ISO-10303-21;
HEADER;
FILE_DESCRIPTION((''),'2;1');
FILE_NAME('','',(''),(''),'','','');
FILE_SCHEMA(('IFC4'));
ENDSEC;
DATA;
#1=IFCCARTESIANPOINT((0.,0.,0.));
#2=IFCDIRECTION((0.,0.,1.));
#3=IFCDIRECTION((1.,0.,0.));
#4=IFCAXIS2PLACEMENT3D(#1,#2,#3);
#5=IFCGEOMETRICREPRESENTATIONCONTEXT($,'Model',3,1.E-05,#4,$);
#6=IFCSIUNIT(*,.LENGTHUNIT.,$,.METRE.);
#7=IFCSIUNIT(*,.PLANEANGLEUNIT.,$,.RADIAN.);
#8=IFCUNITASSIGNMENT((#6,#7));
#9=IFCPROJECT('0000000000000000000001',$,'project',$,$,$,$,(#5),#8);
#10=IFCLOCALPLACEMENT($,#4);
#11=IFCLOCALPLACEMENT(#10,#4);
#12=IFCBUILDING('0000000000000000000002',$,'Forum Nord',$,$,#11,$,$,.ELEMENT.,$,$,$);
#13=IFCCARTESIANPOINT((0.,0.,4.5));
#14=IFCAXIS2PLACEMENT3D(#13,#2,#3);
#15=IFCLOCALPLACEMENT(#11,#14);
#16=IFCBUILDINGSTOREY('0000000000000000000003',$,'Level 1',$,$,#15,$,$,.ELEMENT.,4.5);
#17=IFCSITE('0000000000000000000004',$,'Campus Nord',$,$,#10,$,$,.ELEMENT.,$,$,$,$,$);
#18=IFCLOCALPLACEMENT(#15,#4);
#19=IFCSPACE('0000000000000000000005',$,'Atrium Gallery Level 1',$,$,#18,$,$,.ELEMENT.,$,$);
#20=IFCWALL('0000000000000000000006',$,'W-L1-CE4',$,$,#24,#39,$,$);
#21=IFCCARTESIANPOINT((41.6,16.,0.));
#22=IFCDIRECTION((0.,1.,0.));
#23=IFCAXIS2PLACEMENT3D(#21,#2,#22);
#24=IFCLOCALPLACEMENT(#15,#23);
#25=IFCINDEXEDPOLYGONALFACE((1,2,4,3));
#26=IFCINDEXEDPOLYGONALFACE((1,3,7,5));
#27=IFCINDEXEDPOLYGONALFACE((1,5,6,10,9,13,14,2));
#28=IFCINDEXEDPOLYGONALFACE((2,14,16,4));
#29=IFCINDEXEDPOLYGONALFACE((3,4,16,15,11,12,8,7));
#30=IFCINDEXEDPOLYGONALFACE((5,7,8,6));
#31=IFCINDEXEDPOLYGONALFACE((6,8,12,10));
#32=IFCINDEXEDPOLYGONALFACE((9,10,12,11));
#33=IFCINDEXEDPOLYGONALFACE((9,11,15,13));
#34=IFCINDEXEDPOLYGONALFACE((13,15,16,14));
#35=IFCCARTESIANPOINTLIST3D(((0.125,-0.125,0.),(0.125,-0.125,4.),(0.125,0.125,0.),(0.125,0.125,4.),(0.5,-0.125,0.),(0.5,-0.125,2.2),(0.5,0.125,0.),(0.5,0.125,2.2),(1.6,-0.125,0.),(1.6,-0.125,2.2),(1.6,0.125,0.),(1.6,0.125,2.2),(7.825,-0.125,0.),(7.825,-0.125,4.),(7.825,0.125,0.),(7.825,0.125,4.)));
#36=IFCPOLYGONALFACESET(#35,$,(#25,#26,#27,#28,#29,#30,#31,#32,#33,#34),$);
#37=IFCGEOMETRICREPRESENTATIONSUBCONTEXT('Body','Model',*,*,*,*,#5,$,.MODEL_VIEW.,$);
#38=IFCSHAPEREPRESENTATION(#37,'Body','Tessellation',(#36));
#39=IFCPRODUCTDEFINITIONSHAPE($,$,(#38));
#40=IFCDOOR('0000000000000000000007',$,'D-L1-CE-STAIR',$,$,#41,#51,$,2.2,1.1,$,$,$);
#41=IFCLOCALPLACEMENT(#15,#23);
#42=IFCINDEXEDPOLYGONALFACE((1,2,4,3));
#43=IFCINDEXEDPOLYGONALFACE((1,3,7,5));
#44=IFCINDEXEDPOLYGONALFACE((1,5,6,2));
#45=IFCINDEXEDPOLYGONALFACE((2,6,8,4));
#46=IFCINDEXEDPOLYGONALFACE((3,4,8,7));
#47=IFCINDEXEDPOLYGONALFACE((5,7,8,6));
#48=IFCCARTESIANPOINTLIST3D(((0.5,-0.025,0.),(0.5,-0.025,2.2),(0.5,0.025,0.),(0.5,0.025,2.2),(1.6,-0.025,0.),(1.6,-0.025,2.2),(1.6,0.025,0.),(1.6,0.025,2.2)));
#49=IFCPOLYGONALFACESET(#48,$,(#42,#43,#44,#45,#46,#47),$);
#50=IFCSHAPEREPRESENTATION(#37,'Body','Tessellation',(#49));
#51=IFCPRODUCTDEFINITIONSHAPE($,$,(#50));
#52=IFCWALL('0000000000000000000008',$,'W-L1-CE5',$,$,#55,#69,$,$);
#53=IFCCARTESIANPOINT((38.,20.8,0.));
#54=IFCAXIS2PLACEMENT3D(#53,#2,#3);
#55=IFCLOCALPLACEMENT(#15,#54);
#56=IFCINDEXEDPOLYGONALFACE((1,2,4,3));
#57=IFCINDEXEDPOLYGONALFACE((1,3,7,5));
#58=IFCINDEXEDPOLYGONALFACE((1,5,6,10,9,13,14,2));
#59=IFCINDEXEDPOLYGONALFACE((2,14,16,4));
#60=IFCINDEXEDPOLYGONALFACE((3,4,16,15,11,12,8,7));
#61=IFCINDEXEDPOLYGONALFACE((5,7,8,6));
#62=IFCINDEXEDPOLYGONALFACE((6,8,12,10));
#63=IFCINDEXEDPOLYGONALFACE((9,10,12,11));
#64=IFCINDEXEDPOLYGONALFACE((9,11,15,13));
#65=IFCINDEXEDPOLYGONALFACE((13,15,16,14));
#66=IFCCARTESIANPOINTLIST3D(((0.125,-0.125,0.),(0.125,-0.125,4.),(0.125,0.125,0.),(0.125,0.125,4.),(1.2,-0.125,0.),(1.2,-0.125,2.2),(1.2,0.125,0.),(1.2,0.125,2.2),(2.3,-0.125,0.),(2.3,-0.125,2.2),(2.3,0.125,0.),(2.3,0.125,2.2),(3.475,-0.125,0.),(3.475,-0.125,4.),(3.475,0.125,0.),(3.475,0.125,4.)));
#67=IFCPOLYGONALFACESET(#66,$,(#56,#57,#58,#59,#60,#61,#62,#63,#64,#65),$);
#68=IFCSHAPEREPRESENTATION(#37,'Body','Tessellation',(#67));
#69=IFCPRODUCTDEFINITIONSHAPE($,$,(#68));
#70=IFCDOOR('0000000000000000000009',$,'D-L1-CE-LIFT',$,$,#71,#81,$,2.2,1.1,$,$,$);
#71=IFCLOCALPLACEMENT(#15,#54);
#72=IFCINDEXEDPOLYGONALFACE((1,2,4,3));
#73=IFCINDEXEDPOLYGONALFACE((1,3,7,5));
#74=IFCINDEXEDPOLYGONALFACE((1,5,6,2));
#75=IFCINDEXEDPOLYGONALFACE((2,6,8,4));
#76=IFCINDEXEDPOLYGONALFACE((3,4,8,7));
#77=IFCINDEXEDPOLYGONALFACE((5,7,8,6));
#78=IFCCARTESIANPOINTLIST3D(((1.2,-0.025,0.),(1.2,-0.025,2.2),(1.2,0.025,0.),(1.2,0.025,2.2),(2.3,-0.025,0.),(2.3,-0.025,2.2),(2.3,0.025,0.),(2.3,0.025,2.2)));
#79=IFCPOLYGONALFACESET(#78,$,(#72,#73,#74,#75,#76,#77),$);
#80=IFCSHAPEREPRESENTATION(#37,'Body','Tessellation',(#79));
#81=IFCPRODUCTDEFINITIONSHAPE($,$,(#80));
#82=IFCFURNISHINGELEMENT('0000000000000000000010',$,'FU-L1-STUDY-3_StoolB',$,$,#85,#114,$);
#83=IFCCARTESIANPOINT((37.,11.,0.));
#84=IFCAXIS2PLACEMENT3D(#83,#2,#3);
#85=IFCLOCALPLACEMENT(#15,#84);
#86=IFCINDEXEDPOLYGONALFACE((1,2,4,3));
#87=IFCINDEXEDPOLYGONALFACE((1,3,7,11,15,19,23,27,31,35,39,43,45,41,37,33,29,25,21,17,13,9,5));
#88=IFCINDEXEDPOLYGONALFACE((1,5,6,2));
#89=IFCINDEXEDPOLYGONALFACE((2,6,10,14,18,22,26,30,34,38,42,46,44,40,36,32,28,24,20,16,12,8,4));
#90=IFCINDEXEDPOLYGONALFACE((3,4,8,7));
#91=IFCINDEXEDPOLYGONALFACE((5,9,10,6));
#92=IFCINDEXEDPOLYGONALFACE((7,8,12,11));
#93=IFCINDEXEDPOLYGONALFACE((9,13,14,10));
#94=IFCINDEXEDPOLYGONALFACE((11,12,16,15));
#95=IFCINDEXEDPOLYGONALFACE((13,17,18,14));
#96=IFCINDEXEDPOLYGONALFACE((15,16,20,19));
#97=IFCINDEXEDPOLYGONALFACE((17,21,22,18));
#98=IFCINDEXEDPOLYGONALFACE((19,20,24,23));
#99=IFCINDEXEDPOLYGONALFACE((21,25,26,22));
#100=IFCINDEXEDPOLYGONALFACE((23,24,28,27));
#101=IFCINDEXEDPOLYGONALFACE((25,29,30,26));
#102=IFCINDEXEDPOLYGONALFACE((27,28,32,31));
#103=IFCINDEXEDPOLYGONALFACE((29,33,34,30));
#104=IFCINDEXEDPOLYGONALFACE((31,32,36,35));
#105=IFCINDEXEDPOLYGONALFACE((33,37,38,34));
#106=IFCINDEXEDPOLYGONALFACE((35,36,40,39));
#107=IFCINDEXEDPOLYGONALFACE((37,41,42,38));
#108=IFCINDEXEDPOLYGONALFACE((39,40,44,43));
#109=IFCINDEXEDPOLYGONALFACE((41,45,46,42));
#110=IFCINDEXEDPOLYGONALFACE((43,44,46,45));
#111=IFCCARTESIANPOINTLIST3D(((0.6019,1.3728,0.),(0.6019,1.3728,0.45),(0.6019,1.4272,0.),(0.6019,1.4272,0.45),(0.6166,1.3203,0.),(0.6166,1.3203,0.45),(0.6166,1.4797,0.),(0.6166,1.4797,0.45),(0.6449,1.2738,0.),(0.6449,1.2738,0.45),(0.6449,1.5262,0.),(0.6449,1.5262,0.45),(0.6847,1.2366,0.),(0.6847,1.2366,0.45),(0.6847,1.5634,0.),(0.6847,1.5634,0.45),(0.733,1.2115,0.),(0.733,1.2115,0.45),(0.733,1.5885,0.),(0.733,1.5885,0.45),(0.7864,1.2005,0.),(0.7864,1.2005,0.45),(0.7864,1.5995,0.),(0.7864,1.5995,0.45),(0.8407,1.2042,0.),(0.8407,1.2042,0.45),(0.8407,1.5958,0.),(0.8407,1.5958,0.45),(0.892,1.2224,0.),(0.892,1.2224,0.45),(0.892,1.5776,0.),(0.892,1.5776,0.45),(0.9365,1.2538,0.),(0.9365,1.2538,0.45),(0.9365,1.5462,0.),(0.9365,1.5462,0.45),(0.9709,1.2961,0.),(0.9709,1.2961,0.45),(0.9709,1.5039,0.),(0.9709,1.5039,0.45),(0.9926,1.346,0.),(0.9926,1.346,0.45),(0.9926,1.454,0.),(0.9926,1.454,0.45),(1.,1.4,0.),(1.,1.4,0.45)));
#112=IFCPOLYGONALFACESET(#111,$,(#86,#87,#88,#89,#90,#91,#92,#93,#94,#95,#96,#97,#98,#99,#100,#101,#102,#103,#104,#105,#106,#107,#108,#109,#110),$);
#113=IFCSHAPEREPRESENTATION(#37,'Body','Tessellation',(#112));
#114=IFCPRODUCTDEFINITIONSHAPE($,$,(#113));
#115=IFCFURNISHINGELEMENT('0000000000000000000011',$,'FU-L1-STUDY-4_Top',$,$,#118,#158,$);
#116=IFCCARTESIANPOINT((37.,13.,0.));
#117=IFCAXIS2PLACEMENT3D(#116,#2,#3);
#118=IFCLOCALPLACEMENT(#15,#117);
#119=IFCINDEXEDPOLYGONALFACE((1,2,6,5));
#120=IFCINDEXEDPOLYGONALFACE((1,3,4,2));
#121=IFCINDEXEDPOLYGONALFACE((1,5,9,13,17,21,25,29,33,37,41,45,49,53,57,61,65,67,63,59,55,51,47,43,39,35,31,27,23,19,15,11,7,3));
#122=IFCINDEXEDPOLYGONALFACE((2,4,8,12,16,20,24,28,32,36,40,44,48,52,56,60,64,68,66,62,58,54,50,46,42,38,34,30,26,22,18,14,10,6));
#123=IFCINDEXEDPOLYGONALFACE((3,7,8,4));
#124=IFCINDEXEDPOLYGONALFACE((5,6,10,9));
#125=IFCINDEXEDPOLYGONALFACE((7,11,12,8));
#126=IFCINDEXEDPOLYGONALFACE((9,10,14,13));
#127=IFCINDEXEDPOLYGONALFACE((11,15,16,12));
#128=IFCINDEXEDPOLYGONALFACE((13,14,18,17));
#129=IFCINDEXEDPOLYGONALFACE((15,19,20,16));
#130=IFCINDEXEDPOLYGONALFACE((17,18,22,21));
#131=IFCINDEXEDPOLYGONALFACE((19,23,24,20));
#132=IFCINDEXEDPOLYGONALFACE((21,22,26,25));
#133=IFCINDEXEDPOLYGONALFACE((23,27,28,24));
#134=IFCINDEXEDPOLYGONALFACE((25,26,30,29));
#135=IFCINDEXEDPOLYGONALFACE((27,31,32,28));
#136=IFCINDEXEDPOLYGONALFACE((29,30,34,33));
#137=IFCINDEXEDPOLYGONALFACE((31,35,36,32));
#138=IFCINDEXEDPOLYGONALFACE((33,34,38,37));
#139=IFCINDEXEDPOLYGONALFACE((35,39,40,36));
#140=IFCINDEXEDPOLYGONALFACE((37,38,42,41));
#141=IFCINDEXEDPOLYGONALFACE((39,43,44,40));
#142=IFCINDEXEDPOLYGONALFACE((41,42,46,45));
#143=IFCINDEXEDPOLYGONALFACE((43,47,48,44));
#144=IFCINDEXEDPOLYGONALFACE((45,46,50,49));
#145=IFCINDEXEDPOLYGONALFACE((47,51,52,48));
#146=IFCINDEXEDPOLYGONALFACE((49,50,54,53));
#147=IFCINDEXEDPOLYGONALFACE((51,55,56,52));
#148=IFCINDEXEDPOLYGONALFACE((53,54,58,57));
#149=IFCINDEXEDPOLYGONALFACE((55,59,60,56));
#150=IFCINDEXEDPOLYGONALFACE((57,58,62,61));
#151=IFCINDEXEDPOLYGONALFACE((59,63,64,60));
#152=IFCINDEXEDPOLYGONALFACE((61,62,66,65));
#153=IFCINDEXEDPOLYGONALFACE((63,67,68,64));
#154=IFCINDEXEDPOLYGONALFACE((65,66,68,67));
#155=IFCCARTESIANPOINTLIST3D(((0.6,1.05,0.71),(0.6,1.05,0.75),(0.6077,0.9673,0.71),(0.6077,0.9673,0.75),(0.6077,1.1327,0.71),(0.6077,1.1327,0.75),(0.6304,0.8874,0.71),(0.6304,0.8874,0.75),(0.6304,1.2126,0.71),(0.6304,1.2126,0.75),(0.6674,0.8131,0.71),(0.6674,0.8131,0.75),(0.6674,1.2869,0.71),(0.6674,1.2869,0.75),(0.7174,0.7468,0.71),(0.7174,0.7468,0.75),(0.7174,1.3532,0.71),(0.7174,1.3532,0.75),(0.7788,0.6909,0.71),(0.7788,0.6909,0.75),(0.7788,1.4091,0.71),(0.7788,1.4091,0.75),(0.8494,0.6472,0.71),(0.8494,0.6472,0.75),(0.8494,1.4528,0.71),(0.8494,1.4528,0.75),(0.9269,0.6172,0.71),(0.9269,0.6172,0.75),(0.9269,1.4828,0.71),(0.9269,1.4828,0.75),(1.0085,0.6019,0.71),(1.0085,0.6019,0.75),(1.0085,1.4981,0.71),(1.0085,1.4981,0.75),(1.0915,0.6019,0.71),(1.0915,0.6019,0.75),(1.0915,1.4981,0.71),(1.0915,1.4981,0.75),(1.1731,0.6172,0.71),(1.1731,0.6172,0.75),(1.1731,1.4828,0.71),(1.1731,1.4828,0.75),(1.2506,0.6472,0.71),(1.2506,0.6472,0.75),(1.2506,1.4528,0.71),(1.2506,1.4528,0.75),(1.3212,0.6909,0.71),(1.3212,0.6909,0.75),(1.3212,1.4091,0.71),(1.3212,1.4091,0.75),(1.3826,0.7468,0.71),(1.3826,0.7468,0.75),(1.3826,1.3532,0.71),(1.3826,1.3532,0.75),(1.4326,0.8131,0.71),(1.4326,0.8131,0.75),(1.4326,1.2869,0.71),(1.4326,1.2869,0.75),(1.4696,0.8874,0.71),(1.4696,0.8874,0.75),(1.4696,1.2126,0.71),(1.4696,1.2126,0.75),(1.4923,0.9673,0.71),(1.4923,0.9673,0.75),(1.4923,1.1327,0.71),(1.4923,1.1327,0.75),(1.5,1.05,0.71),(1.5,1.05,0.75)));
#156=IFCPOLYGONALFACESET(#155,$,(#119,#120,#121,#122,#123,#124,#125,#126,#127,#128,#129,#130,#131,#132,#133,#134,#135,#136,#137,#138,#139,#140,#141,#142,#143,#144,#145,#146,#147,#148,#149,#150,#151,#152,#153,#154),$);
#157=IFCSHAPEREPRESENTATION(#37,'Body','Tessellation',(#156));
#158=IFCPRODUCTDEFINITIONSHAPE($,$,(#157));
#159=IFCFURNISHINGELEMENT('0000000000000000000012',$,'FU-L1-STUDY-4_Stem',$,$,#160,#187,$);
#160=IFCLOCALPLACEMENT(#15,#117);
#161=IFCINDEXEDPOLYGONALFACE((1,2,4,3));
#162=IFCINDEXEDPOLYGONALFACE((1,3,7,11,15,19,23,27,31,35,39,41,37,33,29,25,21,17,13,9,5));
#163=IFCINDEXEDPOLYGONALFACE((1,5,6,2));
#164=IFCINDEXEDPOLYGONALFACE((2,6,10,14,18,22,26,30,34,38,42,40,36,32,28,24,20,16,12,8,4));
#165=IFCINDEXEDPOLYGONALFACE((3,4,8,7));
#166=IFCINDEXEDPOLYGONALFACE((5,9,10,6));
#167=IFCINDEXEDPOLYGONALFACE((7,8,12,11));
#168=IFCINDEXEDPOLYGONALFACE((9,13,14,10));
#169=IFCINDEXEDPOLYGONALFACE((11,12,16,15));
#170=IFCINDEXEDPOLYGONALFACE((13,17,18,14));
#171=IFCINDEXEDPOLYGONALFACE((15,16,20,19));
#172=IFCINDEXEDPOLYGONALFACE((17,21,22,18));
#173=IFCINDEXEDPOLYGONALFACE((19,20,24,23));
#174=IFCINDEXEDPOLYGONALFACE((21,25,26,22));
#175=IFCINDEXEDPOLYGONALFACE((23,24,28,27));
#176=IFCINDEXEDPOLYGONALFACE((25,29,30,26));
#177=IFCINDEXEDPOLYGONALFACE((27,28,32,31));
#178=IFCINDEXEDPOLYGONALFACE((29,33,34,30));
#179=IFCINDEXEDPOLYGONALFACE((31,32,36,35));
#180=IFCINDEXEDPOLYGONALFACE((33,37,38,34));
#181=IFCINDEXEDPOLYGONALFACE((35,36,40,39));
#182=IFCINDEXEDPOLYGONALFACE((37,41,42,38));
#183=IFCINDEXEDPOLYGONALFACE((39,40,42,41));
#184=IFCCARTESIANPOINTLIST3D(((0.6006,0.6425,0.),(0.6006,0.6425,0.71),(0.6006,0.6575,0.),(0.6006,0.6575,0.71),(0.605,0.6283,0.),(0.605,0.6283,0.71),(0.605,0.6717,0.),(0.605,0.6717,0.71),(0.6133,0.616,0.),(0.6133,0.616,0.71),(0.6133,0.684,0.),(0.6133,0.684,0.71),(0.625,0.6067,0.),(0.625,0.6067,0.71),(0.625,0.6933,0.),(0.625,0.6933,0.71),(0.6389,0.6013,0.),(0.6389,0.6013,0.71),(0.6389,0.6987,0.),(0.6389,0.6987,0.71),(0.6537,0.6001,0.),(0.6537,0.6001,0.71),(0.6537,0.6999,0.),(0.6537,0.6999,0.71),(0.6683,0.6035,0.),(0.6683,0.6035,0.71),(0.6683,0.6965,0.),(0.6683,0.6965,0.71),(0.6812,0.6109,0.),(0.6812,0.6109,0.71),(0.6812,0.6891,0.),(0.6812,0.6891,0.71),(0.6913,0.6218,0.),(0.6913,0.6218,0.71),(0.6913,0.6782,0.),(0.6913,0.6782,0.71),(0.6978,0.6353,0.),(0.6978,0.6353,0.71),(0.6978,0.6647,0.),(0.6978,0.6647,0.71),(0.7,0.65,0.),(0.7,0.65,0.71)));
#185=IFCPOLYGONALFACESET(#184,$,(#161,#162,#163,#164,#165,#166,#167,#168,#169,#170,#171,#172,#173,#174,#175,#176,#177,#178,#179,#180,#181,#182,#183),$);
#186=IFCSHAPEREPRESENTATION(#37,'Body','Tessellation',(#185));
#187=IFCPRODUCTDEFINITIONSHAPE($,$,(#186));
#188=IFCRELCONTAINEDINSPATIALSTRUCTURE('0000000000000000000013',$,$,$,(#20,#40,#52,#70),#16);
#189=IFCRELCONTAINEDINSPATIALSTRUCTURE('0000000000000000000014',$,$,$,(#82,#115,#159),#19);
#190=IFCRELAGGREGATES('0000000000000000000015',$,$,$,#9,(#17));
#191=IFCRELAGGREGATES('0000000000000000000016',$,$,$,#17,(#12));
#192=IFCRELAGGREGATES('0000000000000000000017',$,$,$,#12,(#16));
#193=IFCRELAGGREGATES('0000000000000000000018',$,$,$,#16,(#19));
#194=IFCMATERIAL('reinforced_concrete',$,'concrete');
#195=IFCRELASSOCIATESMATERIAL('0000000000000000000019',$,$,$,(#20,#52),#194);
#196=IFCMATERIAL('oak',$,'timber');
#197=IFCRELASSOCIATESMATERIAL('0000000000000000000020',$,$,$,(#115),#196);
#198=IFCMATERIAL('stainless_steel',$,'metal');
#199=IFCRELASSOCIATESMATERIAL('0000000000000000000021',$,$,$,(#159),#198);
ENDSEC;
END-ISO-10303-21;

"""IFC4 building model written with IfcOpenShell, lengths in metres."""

from ifc_helpers import new_model, si_unit, frame, frame_2d, origin_with_axes, place, context, subcontext, project, spatial, polyline, rectangle, circle, outline, extrude, material, element, fill, save


model = new_model("IFC4")

# Units and contexts
model_context = context("Model", 3, precision=1e-05, world=origin_with_axes())
body_context = subcontext(model_context, "Body", "Model", "MODEL_VIEW")
ifc_project = project(units=[si_unit("LENGTHUNIT", "METRE"), si_unit("PLANEANGLEUNIT", "RADIAN")], contexts=[model_context])

# Site, building, storey
site_placement = place(None, origin_with_axes())
site = spatial("IfcSite", under=ifc_project, at=site_placement, Name="Campus Nord", CompositionType="ELEMENT")
building_placement = place(site_placement, origin_with_axes())
building = spatial("IfcBuilding", under=site, at=building_placement, Name="Forum Nord", CompositionType="ELEMENT")
storey_placement = place(building_placement, frame((0.0, 0.0, 4.5), z_axis=(0.0, 0.0, 1.0), x_axis=(1.0, 0.0, 0.0)))
storey = spatial("IfcBuildingStorey", under=building, at=storey_placement, Name="Level 1", CompositionType="ELEMENT", Elevation=4.5)

# Shared definitions
ifc_material_1 = material(Name="reinforced_concrete", Category="concrete")

# Walls, openings, doors
wall_1_placement = place(storey_placement, frame((41.6, 16.0, 0.0), z_axis=(0.0, 0.0, 1.0), x_axis=(0.0, 1.0, 0.0)))
wall_1 = element("IfcWall", 1, at=wall_1_placement, inside=storey, material=ifc_material_1, Name="W-L1-CE4", context=body_context, shape_type="SweptSolid", body=[
    extrude(outline(polyline([(0.125, -0.125), (7.825, -0.125), (7.825, 0.125), (0.125, 0.125), (0.125, -0.125)])), origin_with_axes(), (0.0, 0.0, 1.0), 4.0),
])
opening_1_placement = place(storey_placement, frame((41.6, 16.0, 0.0), z_axis=(0.0, 0.0, 1.0), x_axis=(0.0, 1.0, 0.0)))
opening_1 = element("IfcOpeningElement", 2, at=opening_1_placement, cuts=wall_1, context=body_context, shape_type="SweptSolid", body=[
    extrude(rectangle(XDim=1.1, YDim=0.25, at=frame_2d((1.05, 0.0), x_axis=(1.0, 0.0))), origin_with_axes(), (0.0, 0.0, 1.0), 2.2),
])
door_1_placement = place(storey_placement, frame((41.6, 16.0, 0.0), z_axis=(0.0, 0.0, 1.0), x_axis=(0.0, 1.0, 0.0)))
door_1 = element("IfcDoor", 3, at=door_1_placement, inside=storey, Name="D-L1-CE-STAIR", OverallHeight=2.2, OverallWidth=1.1, context=body_context, shape_type="SweptSolid", body=[
    extrude(rectangle(XDim=1.1, YDim=0.05, at=frame_2d((1.05, 0.0), x_axis=(1.0, 0.0))), origin_with_axes(), (0.0, 0.0, 1.0), 2.2),
])
fill(opening_1, door_1)
wall_2_placement = place(storey_placement, frame((38.0, 20.8, 0.0), z_axis=(0.0, 0.0, 1.0), x_axis=(1.0, 0.0, 0.0)))
wall_2 = element("IfcWall", 4, at=wall_2_placement, inside=storey, material=ifc_material_1, Name="W-L1-CE5", context=body_context, shape_type="SweptSolid", body=[
    extrude(outline(polyline([(0.125, -0.125), (3.475, -0.125), (3.475, 0.125), (0.125, 0.125), (0.125, -0.125)])), origin_with_axes(), (0.0, 0.0, 1.0), 4.0),
])
opening_2_placement = place(storey_placement, frame((38.0, 20.8, 0.0), z_axis=(0.0, 0.0, 1.0), x_axis=(1.0, 0.0, 0.0)))
opening_2 = element("IfcOpeningElement", 5, at=opening_2_placement, cuts=wall_2, context=body_context, shape_type="SweptSolid", body=[
    extrude(rectangle(XDim=1.1, YDim=0.25, at=frame_2d((1.75, 0.0), x_axis=(1.0, 0.0))), origin_with_axes(), (0.0, 0.0, 1.0), 2.2),
])
door_2_placement = place(storey_placement, frame((38.0, 20.8, 0.0), z_axis=(0.0, 0.0, 1.0), x_axis=(1.0, 0.0, 0.0)))
door_2 = element("IfcDoor", 6, at=door_2_placement, inside=storey, Name="D-L1-CE-LIFT", OverallHeight=2.2, OverallWidth=1.1, context=body_context, shape_type="SweptSolid", body=[
    extrude(rectangle(XDim=1.1, YDim=0.05, at=frame_2d((1.75, 0.0), x_axis=(1.0, 0.0))), origin_with_axes(), (0.0, 0.0, 1.0), 2.2),
])
fill(opening_2, door_2)

# Shared definitions
space_placement = place(storey_placement, origin_with_axes())
space = spatial("IfcSpace", under=storey, at=space_placement, Name="Atrium Gallery Level 1", CompositionType="ELEMENT")

# Furnishing elements
furnishing_1_placement = place(storey_placement, frame((37.0, 11.0, 0.0), z_axis=(0.0, 0.0, 1.0), x_axis=(1.0, 0.0, 0.0)))
element("IfcFurnishingElement", 7, at=furnishing_1_placement, inside=space, Name="FU-L1-STUDY-3_StoolB", context=body_context, shape_type="SweptSolid", body=[
    extrude(circle(Radius=0.2, at=frame_2d((0.8, 1.4), x_axis=(1.0, 0.0))), origin_with_axes(), (0.0, 0.0, 1.0), 0.45),
])
ifc_material_2 = material(Name="oak", Category="timber")
furnishing_2_placement = place(storey_placement, frame((37.0, 13.0, 0.0), z_axis=(0.0, 0.0, 1.0), x_axis=(1.0, 0.0, 0.0)))
element("IfcFurnishingElement", 8, at=furnishing_2_placement, inside=space, material=ifc_material_2, Name="FU-L1-STUDY-4_Top", context=body_context, shape_type="SweptSolid", body=[
    extrude(circle(Radius=0.45, at=frame_2d((1.05, 1.05), x_axis=(1.0, 0.0))), frame((0.0, 0.0, 0.71), z_axis=(0.0, 0.0, 1.0), x_axis=(1.0, 0.0, 0.0)), (0.0, 0.0, 1.0), 0.04),
])
ifc_material_3 = material(Name="stainless_steel", Category="metal")
furnishing_3_placement = place(storey_placement, frame((37.0, 13.0, 0.0), z_axis=(0.0, 0.0, 1.0), x_axis=(1.0, 0.0, 0.0)))
element("IfcFurnishingElement", 9, at=furnishing_3_placement, inside=space, material=ifc_material_3, Name="FU-L1-STUDY-4_Stem", context=body_context, shape_type="SweptSolid", body=[
    extrude(circle(Radius=0.05, at=frame_2d((0.65, 0.65), x_axis=(1.0, 0.0))), origin_with_axes(), (0.0, 0.0, 1.0), 0.71),
])

save(model, "model.ifc")
